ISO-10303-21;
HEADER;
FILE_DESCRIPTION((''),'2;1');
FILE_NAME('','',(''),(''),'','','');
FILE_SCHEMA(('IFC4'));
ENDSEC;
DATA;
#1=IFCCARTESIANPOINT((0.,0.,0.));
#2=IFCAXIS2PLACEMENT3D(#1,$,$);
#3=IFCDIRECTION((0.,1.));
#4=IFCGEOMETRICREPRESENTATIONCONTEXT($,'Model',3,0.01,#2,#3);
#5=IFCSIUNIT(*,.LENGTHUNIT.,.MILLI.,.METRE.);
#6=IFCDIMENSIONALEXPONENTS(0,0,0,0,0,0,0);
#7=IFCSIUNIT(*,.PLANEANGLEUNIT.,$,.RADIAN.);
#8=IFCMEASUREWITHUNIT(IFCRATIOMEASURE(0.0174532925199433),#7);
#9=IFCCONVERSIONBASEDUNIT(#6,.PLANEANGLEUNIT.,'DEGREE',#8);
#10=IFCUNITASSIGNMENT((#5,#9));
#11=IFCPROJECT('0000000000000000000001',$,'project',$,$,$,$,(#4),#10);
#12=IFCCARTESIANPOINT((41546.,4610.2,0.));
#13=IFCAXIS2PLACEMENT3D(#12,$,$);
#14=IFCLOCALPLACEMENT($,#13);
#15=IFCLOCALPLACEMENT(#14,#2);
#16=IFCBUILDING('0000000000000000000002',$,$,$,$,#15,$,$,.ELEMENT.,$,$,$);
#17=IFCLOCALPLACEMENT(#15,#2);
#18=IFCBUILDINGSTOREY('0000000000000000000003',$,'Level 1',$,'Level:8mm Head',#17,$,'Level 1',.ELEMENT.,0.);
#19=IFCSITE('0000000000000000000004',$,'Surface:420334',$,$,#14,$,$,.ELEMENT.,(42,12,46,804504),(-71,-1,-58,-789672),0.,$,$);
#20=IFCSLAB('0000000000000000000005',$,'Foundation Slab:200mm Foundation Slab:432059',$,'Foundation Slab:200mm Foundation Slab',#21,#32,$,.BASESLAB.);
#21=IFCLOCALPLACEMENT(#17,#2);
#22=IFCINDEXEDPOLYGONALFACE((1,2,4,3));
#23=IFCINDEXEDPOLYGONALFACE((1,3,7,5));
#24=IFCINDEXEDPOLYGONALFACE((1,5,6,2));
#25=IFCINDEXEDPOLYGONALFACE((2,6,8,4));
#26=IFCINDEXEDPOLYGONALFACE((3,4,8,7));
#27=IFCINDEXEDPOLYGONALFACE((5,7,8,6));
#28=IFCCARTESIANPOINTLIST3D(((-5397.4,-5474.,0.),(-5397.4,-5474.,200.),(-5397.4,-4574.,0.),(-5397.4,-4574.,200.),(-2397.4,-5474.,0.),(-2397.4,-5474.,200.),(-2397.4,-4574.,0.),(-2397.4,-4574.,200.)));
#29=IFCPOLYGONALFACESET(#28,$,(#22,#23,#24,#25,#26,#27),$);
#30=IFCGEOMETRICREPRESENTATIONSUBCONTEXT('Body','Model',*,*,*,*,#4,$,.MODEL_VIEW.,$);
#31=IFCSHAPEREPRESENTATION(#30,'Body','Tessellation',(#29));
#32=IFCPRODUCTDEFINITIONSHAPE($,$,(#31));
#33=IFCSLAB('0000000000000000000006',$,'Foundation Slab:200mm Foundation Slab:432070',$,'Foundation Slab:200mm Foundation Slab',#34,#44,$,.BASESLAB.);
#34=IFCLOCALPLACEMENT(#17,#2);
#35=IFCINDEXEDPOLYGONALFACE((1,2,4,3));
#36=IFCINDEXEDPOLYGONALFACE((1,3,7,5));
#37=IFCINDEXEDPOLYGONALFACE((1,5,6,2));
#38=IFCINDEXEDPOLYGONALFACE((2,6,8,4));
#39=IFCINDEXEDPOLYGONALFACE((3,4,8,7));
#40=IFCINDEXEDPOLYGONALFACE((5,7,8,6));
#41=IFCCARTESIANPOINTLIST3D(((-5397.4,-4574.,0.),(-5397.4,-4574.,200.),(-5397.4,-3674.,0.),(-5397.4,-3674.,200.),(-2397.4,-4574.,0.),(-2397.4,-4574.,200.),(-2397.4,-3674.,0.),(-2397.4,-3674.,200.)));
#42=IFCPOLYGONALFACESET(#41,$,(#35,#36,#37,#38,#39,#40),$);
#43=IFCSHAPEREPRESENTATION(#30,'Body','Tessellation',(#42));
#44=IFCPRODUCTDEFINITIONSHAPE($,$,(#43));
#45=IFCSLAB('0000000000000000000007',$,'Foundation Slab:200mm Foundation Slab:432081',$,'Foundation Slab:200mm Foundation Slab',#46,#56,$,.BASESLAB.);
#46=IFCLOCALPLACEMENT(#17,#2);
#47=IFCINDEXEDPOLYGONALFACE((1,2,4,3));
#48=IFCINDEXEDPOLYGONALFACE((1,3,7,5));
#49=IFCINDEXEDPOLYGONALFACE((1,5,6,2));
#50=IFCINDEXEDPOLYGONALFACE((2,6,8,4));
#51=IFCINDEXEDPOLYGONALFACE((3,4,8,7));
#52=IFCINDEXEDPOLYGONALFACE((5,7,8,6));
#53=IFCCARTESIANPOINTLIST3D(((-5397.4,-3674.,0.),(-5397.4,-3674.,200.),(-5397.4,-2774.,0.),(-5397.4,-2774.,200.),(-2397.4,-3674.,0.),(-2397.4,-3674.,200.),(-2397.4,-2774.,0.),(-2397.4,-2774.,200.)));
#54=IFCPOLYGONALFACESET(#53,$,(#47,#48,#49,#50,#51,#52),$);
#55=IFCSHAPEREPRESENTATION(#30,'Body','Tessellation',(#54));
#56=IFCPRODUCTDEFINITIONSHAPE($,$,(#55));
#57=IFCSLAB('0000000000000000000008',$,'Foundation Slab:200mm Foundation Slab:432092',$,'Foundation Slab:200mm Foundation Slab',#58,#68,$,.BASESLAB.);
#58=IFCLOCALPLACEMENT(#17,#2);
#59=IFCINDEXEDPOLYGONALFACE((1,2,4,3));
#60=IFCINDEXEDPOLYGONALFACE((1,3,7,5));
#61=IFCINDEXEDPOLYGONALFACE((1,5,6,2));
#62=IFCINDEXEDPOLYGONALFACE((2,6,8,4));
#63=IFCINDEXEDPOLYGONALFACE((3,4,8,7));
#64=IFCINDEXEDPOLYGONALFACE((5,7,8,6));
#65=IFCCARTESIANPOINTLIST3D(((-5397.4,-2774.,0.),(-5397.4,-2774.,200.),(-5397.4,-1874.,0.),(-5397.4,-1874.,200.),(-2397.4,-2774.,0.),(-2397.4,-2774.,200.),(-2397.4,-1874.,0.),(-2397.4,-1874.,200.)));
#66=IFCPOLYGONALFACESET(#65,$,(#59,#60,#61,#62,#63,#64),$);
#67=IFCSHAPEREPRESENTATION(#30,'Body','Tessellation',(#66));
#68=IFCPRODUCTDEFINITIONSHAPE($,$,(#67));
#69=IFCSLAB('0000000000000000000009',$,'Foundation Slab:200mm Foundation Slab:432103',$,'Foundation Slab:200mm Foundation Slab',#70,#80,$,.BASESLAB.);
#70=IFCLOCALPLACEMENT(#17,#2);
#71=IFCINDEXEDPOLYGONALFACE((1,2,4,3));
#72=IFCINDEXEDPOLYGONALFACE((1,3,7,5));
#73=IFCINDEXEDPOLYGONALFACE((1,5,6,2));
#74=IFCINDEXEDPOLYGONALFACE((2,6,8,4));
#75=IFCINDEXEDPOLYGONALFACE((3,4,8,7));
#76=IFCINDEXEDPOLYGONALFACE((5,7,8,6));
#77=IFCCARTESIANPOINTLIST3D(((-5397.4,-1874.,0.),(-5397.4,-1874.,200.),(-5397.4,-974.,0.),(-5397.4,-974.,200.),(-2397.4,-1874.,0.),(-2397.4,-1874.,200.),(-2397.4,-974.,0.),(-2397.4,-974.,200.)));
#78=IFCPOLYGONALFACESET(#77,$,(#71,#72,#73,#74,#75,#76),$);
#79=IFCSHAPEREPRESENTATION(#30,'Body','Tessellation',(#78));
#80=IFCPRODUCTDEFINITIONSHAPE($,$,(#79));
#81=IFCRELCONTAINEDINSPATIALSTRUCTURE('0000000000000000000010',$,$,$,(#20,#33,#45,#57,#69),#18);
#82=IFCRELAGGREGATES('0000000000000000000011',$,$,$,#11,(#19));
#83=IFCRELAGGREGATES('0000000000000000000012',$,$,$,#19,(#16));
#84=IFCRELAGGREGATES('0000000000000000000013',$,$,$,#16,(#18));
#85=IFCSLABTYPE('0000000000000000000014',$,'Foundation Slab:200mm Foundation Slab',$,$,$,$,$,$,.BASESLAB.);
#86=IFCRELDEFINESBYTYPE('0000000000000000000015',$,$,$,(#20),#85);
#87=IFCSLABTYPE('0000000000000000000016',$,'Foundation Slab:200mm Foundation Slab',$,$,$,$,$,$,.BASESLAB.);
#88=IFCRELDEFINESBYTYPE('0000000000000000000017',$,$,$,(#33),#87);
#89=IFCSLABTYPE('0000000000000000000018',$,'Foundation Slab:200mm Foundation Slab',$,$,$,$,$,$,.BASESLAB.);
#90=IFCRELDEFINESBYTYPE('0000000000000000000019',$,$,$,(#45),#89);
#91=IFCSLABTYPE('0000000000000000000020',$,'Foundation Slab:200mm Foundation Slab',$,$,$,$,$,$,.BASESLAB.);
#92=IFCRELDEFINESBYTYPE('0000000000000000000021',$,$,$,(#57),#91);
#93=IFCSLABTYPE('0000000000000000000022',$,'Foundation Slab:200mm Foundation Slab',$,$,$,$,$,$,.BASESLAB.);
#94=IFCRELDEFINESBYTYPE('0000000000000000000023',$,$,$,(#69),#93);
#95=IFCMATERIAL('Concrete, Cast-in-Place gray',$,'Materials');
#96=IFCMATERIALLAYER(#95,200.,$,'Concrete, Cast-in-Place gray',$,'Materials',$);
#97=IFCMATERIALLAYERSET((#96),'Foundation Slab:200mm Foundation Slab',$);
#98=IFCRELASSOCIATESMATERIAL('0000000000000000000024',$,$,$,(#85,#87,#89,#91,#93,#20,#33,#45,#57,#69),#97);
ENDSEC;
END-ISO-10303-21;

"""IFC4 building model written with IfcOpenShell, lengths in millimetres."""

from ifc_helpers import new_model, entity, si_unit, converted_unit, direction, frame, origin, origin_2d_with_axis, place, context, subcontext, project, spatial, rectangle, extrude, material, layer, layer_set, layer_usage, type_object, element, save


model = new_model("IFC4")

# Units and contexts
model_context = context("Model", 3, precision=0.01, world=origin(), true_north=direction((0.0, 1.0)))
body_context = subcontext(model_context, "Body", "Model", "MODEL_VIEW")
ifc_project = project(units=[si_unit("LENGTHUNIT", "METRE", prefix="MILLI"), converted_unit("PLANEANGLEUNIT", "DEGREE", entity("IfcRatioMeasure", 0.0174532925199433), si_unit("PLANEANGLEUNIT", "RADIAN"), dimensions=[0, 0, 0, 0, 0, 0, 0])], contexts=[model_context])

# Site, building, storey
site_placement = place(None, frame((41546.0, 4610.2, 0.0)))
site = spatial("IfcSite", under=ifc_project, at=site_placement, Name="Surface:420334", CompositionType="ELEMENT", RefLatitude=(42, 12, 46, 804504), RefLongitude=(-71, -1, -58, -789672), RefElevation=0.0)
building_placement = place(site_placement, origin())
building = spatial("IfcBuilding", under=site, at=building_placement, CompositionType="ELEMENT")
storey_placement = place(building_placement, origin())
storey = spatial("IfcBuildingStorey", under=building, at=storey_placement, Name="Level 1", ObjectType="Level:8mm Head", LongName="Level 1", CompositionType="ELEMENT", Elevation=0.0)

# Slabs
ifc_material_1 = material(Name="Concrete, Cast-in-Place gray", Category="Materials")
ifc_layer_1 = layer(ifc_material_1, 200.0, Name="Concrete, Cast-in-Place gray", Category="Materials")
ifc_layer_set_1 = layer_set([ifc_layer_1], Name="Foundation Slab:200mm Foundation Slab")
ifc_layer_usage_1 = layer_usage(ifc_layer_set_1, "AXIS3", "POSITIVE", 0.0)
slab_type_1 = type_object("IfcSlabType", Name="Foundation Slab:200mm Foundation Slab", PredefinedType="BASESLAB", material=ifc_layer_set_1)
slab_1_placement = place(storey_placement, origin())
element("IfcSlab", 1, at=slab_1_placement, inside=storey, type_object=slab_type_1, material=ifc_layer_usage_1, Name="Foundation Slab:200mm Foundation Slab:432059", ObjectType="Foundation Slab:200mm Foundation Slab", PredefinedType="BASESLAB", context=body_context, shape_type="SweptSolid", body=[
    extrude(rectangle(XDim=900.0, YDim=3000.0, at=origin_2d_with_axis()), frame((-3897.4, -5024.0, 200.0), z_axis=(0.0, 0.0, -1.0), x_axis=(0.0, 1.0, 0.0)), (0.0, 0.0, 1.0), 200.0),
])
ifc_layer_usage_2 = layer_usage(ifc_layer_set_1, "AXIS3", "POSITIVE", 0.0)
slab_type_2 = type_object("IfcSlabType", Name="Foundation Slab:200mm Foundation Slab", PredefinedType="BASESLAB", material=ifc_layer_set_1)
slab_2_placement = place(storey_placement, origin())
element("IfcSlab", 2, at=slab_2_placement, inside=storey, type_object=slab_type_2, material=ifc_layer_usage_2, Name="Foundation Slab:200mm Foundation Slab:432070", ObjectType="Foundation Slab:200mm Foundation Slab", PredefinedType="BASESLAB", context=body_context, shape_type="SweptSolid", body=[
    extrude(rectangle(XDim=900.0, YDim=3000.0, at=origin_2d_with_axis()), frame((-3897.4, -4124.0, 200.0), z_axis=(0.0, 0.0, -1.0), x_axis=(0.0, 1.0, 0.0)), (0.0, 0.0, 1.0), 200.0),
])
ifc_layer_usage_3 = layer_usage(ifc_layer_set_1, "AXIS3", "POSITIVE", 0.0)
slab_type_3 = type_object("IfcSlabType", Name="Foundation Slab:200mm Foundation Slab", PredefinedType="BASESLAB", material=ifc_layer_set_1)
slab_3_placement = place(storey_placement, origin())
element("IfcSlab", 3, at=slab_3_placement, inside=storey, type_object=slab_type_3, material=ifc_layer_usage_3, Name="Foundation Slab:200mm Foundation Slab:432081", ObjectType="Foundation Slab:200mm Foundation Slab", PredefinedType="BASESLAB", context=body_context, shape_type="SweptSolid", body=[
    extrude(rectangle(XDim=900.0, YDim=3000.0, at=origin_2d_with_axis()), frame((-3897.4, -3224.0, 200.0), z_axis=(0.0, 0.0, -1.0), x_axis=(0.0, 1.0, 0.0)), (0.0, 0.0, 1.0), 200.0),
])
ifc_layer_usage_4 = layer_usage(ifc_layer_set_1, "AXIS3", "POSITIVE", 0.0)
slab_type_4 = type_object("IfcSlabType", Name="Foundation Slab:200mm Foundation Slab", PredefinedType="BASESLAB", material=ifc_layer_set_1)
slab_4_placement = place(storey_placement, origin())
element("IfcSlab", 4, at=slab_4_placement, inside=storey, type_object=slab_type_4, material=ifc_layer_usage_4, Name="Foundation Slab:200mm Foundation Slab:432092", ObjectType="Foundation Slab:200mm Foundation Slab", PredefinedType="BASESLAB", context=body_context, shape_type="SweptSolid", body=[
    extrude(rectangle(XDim=900.0, YDim=3000.0, at=origin_2d_with_axis()), frame((-3897.4, -2324.0, 200.0), z_axis=(0.0, 0.0, -1.0), x_axis=(0.0, 1.0, 0.0)), (0.0, 0.0, 1.0), 200.0),
])
ifc_layer_usage_5 = layer_usage(ifc_layer_set_1, "AXIS3", "POSITIVE", 0.0)
slab_type_5 = type_object("IfcSlabType", Name="Foundation Slab:200mm Foundation Slab", PredefinedType="BASESLAB", material=ifc_layer_set_1)
slab_5_placement = place(storey_placement, origin())
element("IfcSlab", 5, at=slab_5_placement, inside=storey, type_object=slab_type_5, material=ifc_layer_usage_5, Name="Foundation Slab:200mm Foundation Slab:432103", ObjectType="Foundation Slab:200mm Foundation Slab", PredefinedType="BASESLAB", context=body_context, shape_type="SweptSolid", body=[
    extrude(rectangle(XDim=900.0, YDim=3000.0, at=origin_2d_with_axis()), frame((-3897.4, -1424.0, 200.0), z_axis=(0.0, 0.0, -1.0), x_axis=(0.0, 1.0, 0.0)), (0.0, 0.0, 1.0), 200.0),
])

save(model, "model.ifc")
